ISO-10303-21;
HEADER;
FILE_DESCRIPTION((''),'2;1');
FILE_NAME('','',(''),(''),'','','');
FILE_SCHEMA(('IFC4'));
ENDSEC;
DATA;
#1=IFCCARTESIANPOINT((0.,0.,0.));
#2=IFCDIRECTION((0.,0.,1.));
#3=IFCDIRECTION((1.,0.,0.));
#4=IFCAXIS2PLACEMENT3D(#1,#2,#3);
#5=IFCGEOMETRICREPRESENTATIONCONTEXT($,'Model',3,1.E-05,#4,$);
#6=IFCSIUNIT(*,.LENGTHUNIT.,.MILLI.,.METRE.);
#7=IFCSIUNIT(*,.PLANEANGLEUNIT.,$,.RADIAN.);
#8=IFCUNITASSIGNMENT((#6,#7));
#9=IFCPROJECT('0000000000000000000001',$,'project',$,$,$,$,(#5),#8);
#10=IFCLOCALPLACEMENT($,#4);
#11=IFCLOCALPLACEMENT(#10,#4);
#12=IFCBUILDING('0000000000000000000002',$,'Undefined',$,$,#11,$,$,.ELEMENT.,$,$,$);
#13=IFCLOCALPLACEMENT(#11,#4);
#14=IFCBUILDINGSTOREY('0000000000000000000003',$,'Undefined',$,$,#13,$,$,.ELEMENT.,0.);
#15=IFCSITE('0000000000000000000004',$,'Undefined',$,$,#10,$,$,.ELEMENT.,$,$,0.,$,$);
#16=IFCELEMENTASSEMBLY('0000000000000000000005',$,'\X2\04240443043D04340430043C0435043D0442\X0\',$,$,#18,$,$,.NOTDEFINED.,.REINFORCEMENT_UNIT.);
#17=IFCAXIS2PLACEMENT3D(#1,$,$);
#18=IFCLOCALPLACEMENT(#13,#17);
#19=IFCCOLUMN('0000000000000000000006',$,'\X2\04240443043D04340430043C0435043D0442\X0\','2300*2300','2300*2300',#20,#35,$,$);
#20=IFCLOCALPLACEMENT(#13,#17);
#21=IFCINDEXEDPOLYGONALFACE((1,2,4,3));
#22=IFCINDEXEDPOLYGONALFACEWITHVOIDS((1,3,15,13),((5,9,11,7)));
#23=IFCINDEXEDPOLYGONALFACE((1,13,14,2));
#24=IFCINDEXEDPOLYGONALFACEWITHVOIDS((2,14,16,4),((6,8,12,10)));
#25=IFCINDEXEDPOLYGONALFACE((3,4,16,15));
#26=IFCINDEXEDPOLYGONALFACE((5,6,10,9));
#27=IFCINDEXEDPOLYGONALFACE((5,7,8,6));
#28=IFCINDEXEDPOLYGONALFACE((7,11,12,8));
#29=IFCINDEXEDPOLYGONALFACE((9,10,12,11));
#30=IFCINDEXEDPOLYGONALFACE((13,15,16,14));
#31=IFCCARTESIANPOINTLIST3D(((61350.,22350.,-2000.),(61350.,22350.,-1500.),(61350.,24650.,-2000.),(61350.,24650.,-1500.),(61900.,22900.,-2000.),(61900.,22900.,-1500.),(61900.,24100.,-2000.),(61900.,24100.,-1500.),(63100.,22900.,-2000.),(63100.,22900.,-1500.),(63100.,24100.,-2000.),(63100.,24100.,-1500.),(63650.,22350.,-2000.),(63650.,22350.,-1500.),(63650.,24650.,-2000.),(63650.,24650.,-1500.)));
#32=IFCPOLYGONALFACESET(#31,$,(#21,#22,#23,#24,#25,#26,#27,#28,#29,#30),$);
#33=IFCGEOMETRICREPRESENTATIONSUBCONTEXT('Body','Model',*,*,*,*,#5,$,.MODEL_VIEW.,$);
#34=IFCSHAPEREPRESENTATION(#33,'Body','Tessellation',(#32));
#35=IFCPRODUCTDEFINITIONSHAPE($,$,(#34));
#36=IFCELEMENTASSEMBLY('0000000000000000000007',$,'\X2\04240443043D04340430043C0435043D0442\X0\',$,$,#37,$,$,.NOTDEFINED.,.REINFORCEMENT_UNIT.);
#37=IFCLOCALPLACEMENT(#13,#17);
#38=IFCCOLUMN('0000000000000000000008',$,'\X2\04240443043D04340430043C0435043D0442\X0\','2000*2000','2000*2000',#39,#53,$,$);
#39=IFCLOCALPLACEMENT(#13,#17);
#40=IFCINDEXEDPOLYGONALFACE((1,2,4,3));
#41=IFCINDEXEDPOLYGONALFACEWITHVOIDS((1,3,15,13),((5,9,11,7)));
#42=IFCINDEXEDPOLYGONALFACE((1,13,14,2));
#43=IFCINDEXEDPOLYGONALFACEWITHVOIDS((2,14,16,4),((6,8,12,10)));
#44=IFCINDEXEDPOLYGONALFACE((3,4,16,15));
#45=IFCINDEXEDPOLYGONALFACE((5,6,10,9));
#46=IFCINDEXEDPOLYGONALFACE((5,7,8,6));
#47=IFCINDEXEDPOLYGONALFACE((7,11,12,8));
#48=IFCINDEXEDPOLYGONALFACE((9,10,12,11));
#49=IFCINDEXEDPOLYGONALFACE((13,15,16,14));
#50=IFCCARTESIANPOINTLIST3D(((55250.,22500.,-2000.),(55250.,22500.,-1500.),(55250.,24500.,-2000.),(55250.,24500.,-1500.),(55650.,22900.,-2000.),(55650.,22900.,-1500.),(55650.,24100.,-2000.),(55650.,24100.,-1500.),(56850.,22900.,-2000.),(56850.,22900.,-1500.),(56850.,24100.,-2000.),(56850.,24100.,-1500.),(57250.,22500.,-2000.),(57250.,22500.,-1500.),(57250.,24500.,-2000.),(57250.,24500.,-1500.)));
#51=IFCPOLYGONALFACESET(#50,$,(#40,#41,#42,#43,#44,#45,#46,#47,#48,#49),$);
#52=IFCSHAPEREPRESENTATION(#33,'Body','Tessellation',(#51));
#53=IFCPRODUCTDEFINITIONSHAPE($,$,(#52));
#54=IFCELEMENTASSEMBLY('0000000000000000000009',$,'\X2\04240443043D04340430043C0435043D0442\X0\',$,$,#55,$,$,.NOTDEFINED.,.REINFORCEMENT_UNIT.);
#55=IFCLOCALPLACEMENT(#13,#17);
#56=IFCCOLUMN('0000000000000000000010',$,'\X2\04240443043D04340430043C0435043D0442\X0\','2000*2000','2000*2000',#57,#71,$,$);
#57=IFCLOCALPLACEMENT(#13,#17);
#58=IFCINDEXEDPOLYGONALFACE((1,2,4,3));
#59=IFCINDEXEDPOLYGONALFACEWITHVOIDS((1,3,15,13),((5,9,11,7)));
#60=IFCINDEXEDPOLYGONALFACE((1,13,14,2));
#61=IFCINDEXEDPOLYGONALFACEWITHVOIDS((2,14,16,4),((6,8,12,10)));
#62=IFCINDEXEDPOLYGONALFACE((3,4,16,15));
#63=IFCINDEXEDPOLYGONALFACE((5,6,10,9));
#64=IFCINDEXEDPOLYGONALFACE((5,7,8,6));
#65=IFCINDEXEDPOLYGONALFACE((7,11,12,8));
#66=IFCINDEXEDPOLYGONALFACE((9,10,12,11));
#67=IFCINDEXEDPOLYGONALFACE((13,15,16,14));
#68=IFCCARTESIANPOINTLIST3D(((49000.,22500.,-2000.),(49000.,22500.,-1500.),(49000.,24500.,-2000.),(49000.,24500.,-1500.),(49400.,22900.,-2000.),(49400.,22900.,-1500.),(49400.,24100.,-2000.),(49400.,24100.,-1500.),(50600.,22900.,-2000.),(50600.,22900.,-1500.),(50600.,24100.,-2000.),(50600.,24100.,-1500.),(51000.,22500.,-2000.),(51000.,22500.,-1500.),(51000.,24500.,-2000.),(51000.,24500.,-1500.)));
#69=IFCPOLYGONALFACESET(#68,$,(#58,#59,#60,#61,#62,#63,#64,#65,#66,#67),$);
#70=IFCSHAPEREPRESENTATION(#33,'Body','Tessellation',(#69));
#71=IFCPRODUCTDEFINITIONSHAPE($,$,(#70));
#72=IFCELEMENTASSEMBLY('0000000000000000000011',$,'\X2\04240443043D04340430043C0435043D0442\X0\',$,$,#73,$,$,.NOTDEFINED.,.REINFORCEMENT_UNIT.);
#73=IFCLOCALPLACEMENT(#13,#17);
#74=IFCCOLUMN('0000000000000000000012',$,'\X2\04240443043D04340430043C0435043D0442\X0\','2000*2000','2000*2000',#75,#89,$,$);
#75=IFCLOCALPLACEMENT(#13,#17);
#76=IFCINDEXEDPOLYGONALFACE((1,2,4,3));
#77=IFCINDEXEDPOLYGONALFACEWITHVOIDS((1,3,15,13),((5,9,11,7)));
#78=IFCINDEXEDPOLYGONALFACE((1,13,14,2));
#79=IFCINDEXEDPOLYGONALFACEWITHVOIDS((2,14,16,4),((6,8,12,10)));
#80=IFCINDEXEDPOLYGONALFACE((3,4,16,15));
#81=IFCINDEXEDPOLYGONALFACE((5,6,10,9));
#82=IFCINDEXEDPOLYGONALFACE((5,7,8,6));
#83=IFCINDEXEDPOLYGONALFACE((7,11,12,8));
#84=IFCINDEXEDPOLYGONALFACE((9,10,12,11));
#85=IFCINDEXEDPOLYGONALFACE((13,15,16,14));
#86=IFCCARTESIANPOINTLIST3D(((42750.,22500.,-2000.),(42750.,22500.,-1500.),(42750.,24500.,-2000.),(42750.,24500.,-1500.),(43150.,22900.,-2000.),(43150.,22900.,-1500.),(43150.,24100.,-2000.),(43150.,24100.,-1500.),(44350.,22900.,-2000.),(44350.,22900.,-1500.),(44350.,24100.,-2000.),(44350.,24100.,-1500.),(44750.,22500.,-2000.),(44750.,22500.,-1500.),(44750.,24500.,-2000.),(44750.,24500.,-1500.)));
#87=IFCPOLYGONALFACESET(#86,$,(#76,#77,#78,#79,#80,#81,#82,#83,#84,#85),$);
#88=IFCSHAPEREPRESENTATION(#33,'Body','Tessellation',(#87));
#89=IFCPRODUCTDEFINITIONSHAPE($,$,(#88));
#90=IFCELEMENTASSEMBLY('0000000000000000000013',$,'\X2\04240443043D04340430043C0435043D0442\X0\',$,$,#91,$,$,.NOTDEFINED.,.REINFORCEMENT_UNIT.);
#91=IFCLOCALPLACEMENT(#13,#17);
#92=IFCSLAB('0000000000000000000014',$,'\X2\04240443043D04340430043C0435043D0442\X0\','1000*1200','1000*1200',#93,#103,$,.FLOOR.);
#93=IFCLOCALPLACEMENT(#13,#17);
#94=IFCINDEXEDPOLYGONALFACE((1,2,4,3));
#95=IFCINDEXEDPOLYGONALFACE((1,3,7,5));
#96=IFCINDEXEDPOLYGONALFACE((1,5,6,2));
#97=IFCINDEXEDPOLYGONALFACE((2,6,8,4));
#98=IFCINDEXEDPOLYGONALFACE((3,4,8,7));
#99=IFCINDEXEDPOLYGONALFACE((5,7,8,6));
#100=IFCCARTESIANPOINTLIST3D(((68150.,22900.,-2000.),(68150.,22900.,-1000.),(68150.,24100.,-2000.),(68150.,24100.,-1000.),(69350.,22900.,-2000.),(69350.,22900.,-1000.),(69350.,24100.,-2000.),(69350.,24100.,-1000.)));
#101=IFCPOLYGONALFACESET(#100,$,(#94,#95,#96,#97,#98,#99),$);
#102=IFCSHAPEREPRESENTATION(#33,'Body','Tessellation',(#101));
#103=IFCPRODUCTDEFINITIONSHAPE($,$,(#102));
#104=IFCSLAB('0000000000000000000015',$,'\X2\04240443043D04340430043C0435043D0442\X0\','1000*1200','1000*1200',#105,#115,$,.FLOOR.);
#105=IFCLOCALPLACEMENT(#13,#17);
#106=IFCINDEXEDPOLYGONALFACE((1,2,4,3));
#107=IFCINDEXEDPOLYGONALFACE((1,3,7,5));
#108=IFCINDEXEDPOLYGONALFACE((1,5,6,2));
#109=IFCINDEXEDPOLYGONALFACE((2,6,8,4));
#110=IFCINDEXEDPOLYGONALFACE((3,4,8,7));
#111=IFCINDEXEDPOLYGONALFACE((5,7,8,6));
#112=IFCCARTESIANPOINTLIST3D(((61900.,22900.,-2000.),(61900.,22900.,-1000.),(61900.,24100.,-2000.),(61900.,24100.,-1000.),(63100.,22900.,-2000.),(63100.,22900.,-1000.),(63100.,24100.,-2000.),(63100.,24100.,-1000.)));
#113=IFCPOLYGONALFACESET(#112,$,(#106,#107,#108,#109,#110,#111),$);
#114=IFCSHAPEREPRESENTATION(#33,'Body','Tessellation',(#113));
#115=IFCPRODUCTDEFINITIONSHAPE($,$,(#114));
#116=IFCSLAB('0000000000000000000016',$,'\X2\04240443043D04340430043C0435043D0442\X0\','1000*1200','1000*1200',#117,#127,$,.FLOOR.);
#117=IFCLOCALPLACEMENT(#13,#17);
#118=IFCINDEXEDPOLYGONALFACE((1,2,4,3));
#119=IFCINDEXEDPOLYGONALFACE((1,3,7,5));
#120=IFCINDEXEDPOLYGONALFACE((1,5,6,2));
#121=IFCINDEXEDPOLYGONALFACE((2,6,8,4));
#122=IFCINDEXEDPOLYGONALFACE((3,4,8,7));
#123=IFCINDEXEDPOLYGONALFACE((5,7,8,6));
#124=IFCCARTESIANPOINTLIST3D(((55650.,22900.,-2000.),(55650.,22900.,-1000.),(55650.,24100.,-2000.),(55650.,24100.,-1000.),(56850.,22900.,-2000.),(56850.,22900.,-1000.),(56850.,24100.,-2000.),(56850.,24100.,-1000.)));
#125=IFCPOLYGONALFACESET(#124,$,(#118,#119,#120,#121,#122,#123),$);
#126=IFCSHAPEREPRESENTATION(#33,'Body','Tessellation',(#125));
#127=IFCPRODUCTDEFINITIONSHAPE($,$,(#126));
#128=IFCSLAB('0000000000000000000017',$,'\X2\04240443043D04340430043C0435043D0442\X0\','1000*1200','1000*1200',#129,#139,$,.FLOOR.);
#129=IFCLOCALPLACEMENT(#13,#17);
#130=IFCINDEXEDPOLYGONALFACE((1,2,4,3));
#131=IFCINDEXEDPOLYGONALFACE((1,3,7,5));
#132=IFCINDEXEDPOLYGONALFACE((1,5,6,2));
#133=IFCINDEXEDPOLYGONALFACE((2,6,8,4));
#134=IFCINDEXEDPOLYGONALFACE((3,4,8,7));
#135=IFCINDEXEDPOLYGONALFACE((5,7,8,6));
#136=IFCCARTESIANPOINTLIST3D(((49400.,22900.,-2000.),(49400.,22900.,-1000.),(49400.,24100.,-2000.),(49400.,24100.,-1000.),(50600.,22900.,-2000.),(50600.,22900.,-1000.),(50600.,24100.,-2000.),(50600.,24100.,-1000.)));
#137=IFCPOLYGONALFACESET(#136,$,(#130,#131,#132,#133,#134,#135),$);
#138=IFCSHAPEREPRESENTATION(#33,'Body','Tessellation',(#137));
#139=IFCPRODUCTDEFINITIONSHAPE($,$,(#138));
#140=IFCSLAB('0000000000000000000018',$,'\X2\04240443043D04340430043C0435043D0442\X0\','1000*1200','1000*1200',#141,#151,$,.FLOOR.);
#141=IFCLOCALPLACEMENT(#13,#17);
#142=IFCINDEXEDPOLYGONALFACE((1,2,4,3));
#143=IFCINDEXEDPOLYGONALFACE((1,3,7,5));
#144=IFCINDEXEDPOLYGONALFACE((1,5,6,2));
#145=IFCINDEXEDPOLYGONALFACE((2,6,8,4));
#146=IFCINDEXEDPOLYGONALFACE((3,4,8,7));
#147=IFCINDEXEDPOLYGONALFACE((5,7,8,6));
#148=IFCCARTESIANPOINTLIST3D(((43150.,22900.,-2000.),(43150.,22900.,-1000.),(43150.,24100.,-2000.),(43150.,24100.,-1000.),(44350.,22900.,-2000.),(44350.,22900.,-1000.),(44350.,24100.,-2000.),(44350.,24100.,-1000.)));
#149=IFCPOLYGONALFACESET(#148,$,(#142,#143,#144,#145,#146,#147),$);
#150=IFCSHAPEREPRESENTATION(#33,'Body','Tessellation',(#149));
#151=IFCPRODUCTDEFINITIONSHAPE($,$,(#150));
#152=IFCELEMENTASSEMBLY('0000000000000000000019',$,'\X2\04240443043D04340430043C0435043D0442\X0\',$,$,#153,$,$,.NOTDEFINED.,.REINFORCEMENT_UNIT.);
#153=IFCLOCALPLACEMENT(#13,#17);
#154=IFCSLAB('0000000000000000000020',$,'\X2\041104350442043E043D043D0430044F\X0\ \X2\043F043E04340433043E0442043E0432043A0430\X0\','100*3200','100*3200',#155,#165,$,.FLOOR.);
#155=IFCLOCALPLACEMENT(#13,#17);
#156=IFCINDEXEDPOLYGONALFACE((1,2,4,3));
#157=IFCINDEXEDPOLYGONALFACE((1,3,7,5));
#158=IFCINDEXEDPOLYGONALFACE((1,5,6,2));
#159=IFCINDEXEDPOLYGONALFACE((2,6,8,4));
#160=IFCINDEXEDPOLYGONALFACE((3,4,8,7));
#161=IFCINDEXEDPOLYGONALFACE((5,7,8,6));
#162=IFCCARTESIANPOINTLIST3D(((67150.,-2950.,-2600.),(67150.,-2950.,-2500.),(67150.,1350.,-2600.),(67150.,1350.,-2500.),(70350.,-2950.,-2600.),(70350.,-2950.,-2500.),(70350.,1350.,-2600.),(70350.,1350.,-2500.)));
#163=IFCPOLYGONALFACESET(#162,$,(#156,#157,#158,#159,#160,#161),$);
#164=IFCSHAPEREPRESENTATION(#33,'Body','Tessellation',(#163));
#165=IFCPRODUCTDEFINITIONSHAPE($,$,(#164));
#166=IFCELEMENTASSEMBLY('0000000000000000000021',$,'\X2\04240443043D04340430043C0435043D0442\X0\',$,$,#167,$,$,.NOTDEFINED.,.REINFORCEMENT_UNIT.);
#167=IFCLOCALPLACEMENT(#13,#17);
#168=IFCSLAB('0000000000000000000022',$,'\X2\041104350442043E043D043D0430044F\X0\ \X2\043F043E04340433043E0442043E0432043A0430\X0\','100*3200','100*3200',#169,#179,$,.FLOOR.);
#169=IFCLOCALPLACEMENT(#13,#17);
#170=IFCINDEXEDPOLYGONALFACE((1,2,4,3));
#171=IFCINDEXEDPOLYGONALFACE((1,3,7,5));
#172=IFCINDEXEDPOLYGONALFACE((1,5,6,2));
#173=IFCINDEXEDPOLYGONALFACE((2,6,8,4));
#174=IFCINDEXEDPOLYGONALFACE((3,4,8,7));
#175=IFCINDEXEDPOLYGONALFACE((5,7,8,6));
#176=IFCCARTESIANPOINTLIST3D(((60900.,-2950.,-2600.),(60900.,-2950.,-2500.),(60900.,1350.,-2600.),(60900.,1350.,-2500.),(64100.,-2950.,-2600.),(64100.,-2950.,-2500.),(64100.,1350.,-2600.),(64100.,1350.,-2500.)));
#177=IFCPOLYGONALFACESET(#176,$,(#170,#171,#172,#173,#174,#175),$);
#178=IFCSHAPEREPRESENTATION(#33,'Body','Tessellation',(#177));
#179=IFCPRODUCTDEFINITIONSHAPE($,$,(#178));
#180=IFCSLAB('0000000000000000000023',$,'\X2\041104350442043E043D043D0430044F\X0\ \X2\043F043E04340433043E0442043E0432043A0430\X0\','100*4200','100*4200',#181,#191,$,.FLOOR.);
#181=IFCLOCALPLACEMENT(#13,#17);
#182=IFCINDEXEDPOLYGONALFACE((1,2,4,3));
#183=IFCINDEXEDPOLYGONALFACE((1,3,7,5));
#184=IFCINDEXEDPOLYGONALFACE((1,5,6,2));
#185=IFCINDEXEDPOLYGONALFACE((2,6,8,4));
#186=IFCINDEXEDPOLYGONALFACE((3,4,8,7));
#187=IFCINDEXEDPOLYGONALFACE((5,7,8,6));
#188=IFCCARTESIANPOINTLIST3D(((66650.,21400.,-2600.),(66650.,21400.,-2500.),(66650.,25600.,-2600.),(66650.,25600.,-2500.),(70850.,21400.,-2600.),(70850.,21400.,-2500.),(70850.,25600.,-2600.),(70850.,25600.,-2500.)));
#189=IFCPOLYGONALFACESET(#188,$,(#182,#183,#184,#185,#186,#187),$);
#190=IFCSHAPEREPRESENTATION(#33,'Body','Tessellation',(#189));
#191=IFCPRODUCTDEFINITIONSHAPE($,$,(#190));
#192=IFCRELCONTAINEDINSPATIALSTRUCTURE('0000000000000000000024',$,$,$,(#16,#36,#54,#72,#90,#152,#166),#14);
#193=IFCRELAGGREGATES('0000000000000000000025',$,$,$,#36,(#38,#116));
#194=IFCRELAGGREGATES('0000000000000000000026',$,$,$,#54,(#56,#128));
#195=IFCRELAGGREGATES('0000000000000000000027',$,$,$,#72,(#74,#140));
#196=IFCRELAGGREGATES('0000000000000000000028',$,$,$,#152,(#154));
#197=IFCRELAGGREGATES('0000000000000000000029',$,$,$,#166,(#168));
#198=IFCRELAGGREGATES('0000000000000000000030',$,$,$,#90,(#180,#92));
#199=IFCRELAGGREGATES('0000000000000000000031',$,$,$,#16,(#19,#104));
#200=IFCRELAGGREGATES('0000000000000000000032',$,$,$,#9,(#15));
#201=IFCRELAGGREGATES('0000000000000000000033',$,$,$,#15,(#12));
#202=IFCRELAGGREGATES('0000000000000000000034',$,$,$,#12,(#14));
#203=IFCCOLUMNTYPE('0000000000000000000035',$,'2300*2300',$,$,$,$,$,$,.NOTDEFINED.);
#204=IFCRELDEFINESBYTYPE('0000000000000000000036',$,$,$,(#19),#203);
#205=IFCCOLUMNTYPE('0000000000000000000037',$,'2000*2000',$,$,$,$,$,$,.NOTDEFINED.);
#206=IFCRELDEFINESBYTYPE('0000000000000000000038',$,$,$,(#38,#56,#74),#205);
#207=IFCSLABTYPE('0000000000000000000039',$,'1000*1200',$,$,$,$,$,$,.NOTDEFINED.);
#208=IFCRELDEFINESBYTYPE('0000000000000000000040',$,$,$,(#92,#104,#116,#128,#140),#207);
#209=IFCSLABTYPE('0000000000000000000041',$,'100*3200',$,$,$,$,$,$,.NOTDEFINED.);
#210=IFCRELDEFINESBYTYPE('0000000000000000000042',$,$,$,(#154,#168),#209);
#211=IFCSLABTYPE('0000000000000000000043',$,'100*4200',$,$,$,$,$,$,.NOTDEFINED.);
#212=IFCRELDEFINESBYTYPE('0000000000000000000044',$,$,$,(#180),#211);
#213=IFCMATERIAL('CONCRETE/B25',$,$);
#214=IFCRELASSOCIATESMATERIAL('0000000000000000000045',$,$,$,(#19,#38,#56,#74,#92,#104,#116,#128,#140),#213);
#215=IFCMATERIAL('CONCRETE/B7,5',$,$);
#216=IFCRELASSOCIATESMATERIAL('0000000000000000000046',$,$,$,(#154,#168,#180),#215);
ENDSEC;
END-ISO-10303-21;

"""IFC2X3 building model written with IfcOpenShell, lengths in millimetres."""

from ifc_helpers import new_model, si_unit, frame, origin_with_axes, origin_2d_with_axis, place, context, subcontext, project, spatial, polyline, rectangle, outline, extrude, boolean, material, type_object, element, aggregate, save


model = new_model("IFC2X3")

# Units and contexts
model_context = context("Model", 3, precision=1e-05, world=origin_with_axes())
body_context = subcontext(model_context, "Body", "Model", "MODEL_VIEW")
ifc_project = project(units=[si_unit("LENGTHUNIT", "METRE", prefix="MILLI"), si_unit("PLANEANGLEUNIT", "RADIAN")], contexts=[model_context])

# Site, building, storey
site_placement = place(None, origin_with_axes())
site = spatial("IfcSite", under=ifc_project, at=site_placement, Name="Undefined", CompositionType="ELEMENT", RefElevation=0.0)
building_placement = place(site_placement, origin_with_axes())
building = spatial("IfcBuilding", under=site, at=building_placement, Name="Undefined", CompositionType="ELEMENT")
storey_placement = place(building_placement, origin_with_axes())
storey = spatial("IfcBuildingStorey", under=building, at=storey_placement, Name="Undefined", CompositionType="ELEMENT", Elevation=0.0)

# Element assemblies, columns
assembly_1_placement = place(storey_placement, origin_with_axes())
assembly_1 = element("IfcElementAssembly", 1, at=assembly_1_placement, inside=storey, Name="Фундамент", AssemblyPlace="NOTDEFINED", PredefinedType="REINFORCEMENT_UNIT")
ifc_material_1 = material(Name="CONCRETE/B25")
column_type_1 = type_object("IfcColumnType", Name="2300*2300", PredefinedType="NOTDEFINED")
column_1_placement = place(assembly_1_placement, frame((62500.0, 23500.0, -2000.0), z_axis=(0.0, 0.0, 1.0), x_axis=(0.0, -1.0, 0.0)))
column_1 = element("IfcColumn", 2, at=column_1_placement, type_object=column_type_1, material=ifc_material_1, Name="Фундамент", Description="2300*2300", ObjectType="2300*2300", context=body_context, shape_type="CSG", body=[
    boolean("DIFFERENCE", extrude(rectangle(XDim=2300.0, YDim=2300.0, at=origin_2d_with_axis()), frame((0.0, 0.0, 500.0), z_axis=(0.0, 0.0, -1.0), x_axis=(0.0, 1.0, 0.0)), (0.0, 0.0, 1.0), 500.0), extrude(outline(polyline([(0.0, 0.0), (1200.0, 0.0), (1200.0, 1200.0), (0.0, 1200.0), (0.0, 0.0)])), frame((-600.0, -600.0, -100.0), z_axis=(0.0, 0.0, 1.0), x_axis=(1.0, 0.0, 0.0)), (0.0, 0.0, 1.0), 700.0)),
])
assembly_2_placement = place(storey_placement, origin_with_axes())
assembly_2 = element("IfcElementAssembly", 3, at=assembly_2_placement, inside=storey, Name="Фундамент", AssemblyPlace="NOTDEFINED", PredefinedType="REINFORCEMENT_UNIT")
column_type_2 = type_object("IfcColumnType", Name="2000*2000", PredefinedType="NOTDEFINED")
column_2_placement = place(assembly_2_placement, frame((56250.0, 23500.0, -2000.0), z_axis=(0.0, 0.0, 1.0), x_axis=(0.0, -1.0, 0.0)))
column_2 = element("IfcColumn", 4, at=column_2_placement, type_object=column_type_2, material=ifc_material_1, Name="Фундамент", Description="2000*2000", ObjectType="2000*2000", context=body_context, shape_type="CSG", body=[
    boolean("DIFFERENCE", extrude(rectangle(XDim=2000.0, YDim=2000.0, at=origin_2d_with_axis()), frame((0.0, 0.0, 500.0), z_axis=(0.0, 0.0, -1.0), x_axis=(0.0, 1.0, 0.0)), (0.0, 0.0, 1.0), 500.0), extrude(outline(polyline([(0.0, 0.0), (1200.0, 0.0), (1200.0, 1200.0), (0.0, 1200.0), (0.0, 0.0)])), frame((-600.0, -600.0, -100.0), z_axis=(0.0, 0.0, 1.0), x_axis=(1.0, 0.0, 0.0)), (0.0, 0.0, 1.0), 700.0)),
])
assembly_3_placement = place(storey_placement, origin_with_axes())
assembly_3 = element("IfcElementAssembly", 5, at=assembly_3_placement, inside=storey, Name="Фундамент", AssemblyPlace="NOTDEFINED", PredefinedType="REINFORCEMENT_UNIT")
column_3_placement = place(assembly_3_placement, frame((50000.0, 23500.0, -2000.0), z_axis=(0.0, 0.0, 1.0), x_axis=(0.0, -1.0, 0.0)))
column_3 = element("IfcColumn", 6, at=column_3_placement, type_object=column_type_2, material=ifc_material_1, Name="Фундамент", Description="2000*2000", ObjectType="2000*2000", context=body_context, shape_type="CSG", body=[
    boolean("DIFFERENCE", extrude(rectangle(XDim=2000.0, YDim=2000.0, at=origin_2d_with_axis()), frame((0.0, 0.0, 500.0), z_axis=(0.0, 0.0, -1.0), x_axis=(0.0, 1.0, 0.0)), (0.0, 0.0, 1.0), 500.0), extrude(outline(polyline([(0.0, 0.0), (1200.0, 0.0), (1200.0, 1200.0), (0.0, 1200.0), (0.0, 0.0)])), frame((-600.0, -600.0, -100.0), z_axis=(0.0, 0.0, 1.0), x_axis=(1.0, 0.0, 0.0)), (0.0, 0.0, 1.0), 700.0)),
])
assembly_4_placement = place(storey_placement, origin_with_axes())
assembly_4 = element("IfcElementAssembly", 7, at=assembly_4_placement, inside=storey, Name="Фундамент", AssemblyPlace="NOTDEFINED", PredefinedType="REINFORCEMENT_UNIT")
column_4_placement = place(assembly_4_placement, frame((43750.0, 23500.0, -2000.0), z_axis=(0.0, 0.0, 1.0), x_axis=(0.0, -1.0, 0.0)))
column_4 = element("IfcColumn", 8, at=column_4_placement, type_object=column_type_2, material=ifc_material_1, Name="Фундамент", Description="2000*2000", ObjectType="2000*2000", context=body_context, shape_type="CSG", body=[
    boolean("DIFFERENCE", extrude(rectangle(XDim=2000.0, YDim=2000.0, at=origin_2d_with_axis()), frame((0.0, 0.0, 500.0), z_axis=(0.0, 0.0, -1.0), x_axis=(0.0, 1.0, 0.0)), (0.0, 0.0, 1.0), 500.0), extrude(outline(polyline([(0.0, 0.0), (1200.0, 0.0), (1200.0, 1200.0), (0.0, 1200.0), (0.0, 0.0)])), frame((-600.0, -600.0, -100.0), z_axis=(0.0, 0.0, 1.0), x_axis=(1.0, 0.0, 0.0)), (0.0, 0.0, 1.0), 700.0)),
])

# Element assembly, slab
assembly_5_placement = place(storey_placement, origin_with_axes())
assembly_5 = element("IfcElementAssembly", 9, at=assembly_5_placement, inside=storey, Name="Фундамент", AssemblyPlace="NOTDEFINED", PredefinedType="REINFORCEMENT_UNIT")
slab_type_1 = type_object("IfcSlabType", Name="1000*1200", PredefinedType="NOTDEFINED")
slab_1_placement = place(assembly_5_placement, frame((68150.0, 24100.0, -1500.0), z_axis=(0.0, 0.0, 1.0), x_axis=(0.0, -1.0, 0.0)))
slab_1 = element("IfcSlab", 10, at=slab_1_placement, type_object=slab_type_1, material=ifc_material_1, Name="Фундамент", Description="1000*1200", ObjectType="1000*1200", PredefinedType="FLOOR", context=body_context, shape_type="SweptSolid", body=[
    extrude(outline(polyline([(0.0, 0.0), (1200.0, 0.0), (1200.0, 1200.0), (0.0, 1200.0), (0.0, 0.0)])), frame((0.0, 0.0, -500.0), z_axis=(0.0, 0.0, 1.0), x_axis=(1.0, 0.0, 0.0)), (0.0, 0.0, 1.0), 1000.0),
])

# Slabs
slab_2_placement = place(assembly_1_placement, frame((61900.0, 24100.0, -1500.0), z_axis=(0.0, 0.0, 1.0), x_axis=(0.0, -1.0, 0.0)))
slab_2 = element("IfcSlab", 11, at=slab_2_placement, type_object=slab_type_1, material=ifc_material_1, Name="Фундамент", Description="1000*1200", ObjectType="1000*1200", PredefinedType="FLOOR", context=body_context, shape_type="SweptSolid", body=[
    extrude(outline(polyline([(0.0, 0.0), (1200.0, 0.0), (1200.0, 1200.0), (0.0, 1200.0), (0.0, 0.0)])), frame((0.0, 0.0, -500.0), z_axis=(0.0, 0.0, 1.0), x_axis=(1.0, 0.0, 0.0)), (0.0, 0.0, 1.0), 1000.0),
])
slab_3_placement = place(assembly_2_placement, frame((55650.0, 24100.0, -1500.0), z_axis=(0.0, 0.0, 1.0), x_axis=(0.0, -1.0, 0.0)))
slab_3 = element("IfcSlab", 12, at=slab_3_placement, type_object=slab_type_1, material=ifc_material_1, Name="Фундамент", Description="1000*1200", ObjectType="1000*1200", PredefinedType="FLOOR", context=body_context, shape_type="SweptSolid", body=[
    extrude(outline(polyline([(0.0, 0.0), (1200.0, 0.0), (1200.0, 1200.0), (0.0, 1200.0), (0.0, 0.0)])), frame((0.0, 0.0, -500.0), z_axis=(0.0, 0.0, 1.0), x_axis=(1.0, 0.0, 0.0)), (0.0, 0.0, 1.0), 1000.0),
])
aggregate(assembly_2, [column_2, slab_3])
slab_4_placement = place(assembly_3_placement, frame((49400.0, 24100.0, -1500.0), z_axis=(0.0, 0.0, 1.0), x_axis=(0.0, -1.0, 0.0)))
slab_4 = element("IfcSlab", 13, at=slab_4_placement, type_object=slab_type_1, material=ifc_material_1, Name="Фундамент", Description="1000*1200", ObjectType="1000*1200", PredefinedType="FLOOR", context=body_context, shape_type="SweptSolid", body=[
    extrude(outline(polyline([(0.0, 0.0), (1200.0, 0.0), (1200.0, 1200.0), (0.0, 1200.0), (0.0, 0.0)])), frame((0.0, 0.0, -500.0), z_axis=(0.0, 0.0, 1.0), x_axis=(1.0, 0.0, 0.0)), (0.0, 0.0, 1.0), 1000.0),
])
aggregate(assembly_3, [column_3, slab_4])
slab_5_placement = place(assembly_4_placement, frame((43150.0, 24100.0, -1500.0), z_axis=(0.0, 0.0, 1.0), x_axis=(0.0, -1.0, 0.0)))
slab_5 = element("IfcSlab", 14, at=slab_5_placement, type_object=slab_type_1, material=ifc_material_1, Name="Фундамент", Description="1000*1200", ObjectType="1000*1200", PredefinedType="FLOOR", context=body_context, shape_type="SweptSolid", body=[
    extrude(outline(polyline([(0.0, 0.0), (1200.0, 0.0), (1200.0, 1200.0), (0.0, 1200.0), (0.0, 0.0)])), frame((0.0, 0.0, -500.0), z_axis=(0.0, 0.0, 1.0), x_axis=(1.0, 0.0, 0.0)), (0.0, 0.0, 1.0), 1000.0),
])
aggregate(assembly_4, [column_4, slab_5])

# Element assemblies, slabs
assembly_6_placement = place(storey_placement, origin_with_axes())
assembly_6 = element("IfcElementAssembly", 15, at=assembly_6_placement, inside=storey, Name="Фундамент", AssemblyPlace="NOTDEFINED", PredefinedType="REINFORCEMENT_UNIT")
ifc_material_2 = material(Name="CONCRETE/B7,5")
slab_type_2 = type_object("IfcSlabType", Name="100*3200", PredefinedType="NOTDEFINED")
slab_6_placement = place(assembly_6_placement, frame((67150.0, 1350.0, -2550.0), z_axis=(0.0, 0.0, 1.0), x_axis=(0.0, -1.0, 0.0)))
slab_6 = element("IfcSlab", 16, at=slab_6_placement, type_object=slab_type_2, material=ifc_material_2, Name="Бетонная подготовка", Description="100*3200", ObjectType="100*3200", PredefinedType="FLOOR", context=body_context, shape_type="SweptSolid", body=[
    extrude(outline(polyline([(0.0, 0.0), (4300.0, 0.0), (4300.0, 3200.0), (0.0, 3200.0), (0.0, 0.0)])), frame((0.0, 0.0, -50.0), z_axis=(0.0, 0.0, 1.0), x_axis=(1.0, 0.0, 0.0)), (0.0, 0.0, 1.0), 100.0),
])
aggregate(assembly_6, [slab_6])
assembly_7_placement = place(storey_placement, origin_with_axes())
assembly_7 = element("IfcElementAssembly", 17, at=assembly_7_placement, inside=storey, Name="Фундамент", AssemblyPlace="NOTDEFINED", PredefinedType="REINFORCEMENT_UNIT")
slab_7_placement = place(assembly_7_placement, frame((60900.0, 1350.0, -2550.0), z_axis=(0.0, 0.0, 1.0), x_axis=(0.0, -1.0, 0.0)))
slab_7 = element("IfcSlab", 18, at=slab_7_placement, type_object=slab_type_2, material=ifc_material_2, Name="Бетонная подготовка", Description="100*3200", ObjectType="100*3200", PredefinedType="FLOOR", context=body_context, shape_type="SweptSolid", body=[
    extrude(outline(polyline([(0.0, 0.0), (4300.0, 0.0), (4300.0, 3200.0), (0.0, 3200.0), (0.0, 0.0)])), frame((0.0, 0.0, -50.0), z_axis=(0.0, 0.0, 1.0), x_axis=(1.0, 0.0, 0.0)), (0.0, 0.0, 1.0), 100.0),
])
aggregate(assembly_7, [slab_7])

# Slab
slab_type_3 = type_object("IfcSlabType", Name="100*4200", PredefinedType="NOTDEFINED")
slab_8_placement = place(assembly_5_placement, frame((66650.0, 25600.0, -2550.0), z_axis=(0.0, 0.0, 1.0), x_axis=(0.0, -1.0, 0.0)))
slab_8 = element("IfcSlab", 19, at=slab_8_placement, type_object=slab_type_3, material=ifc_material_2, Name="Бетонная подготовка", Description="100*4200", ObjectType="100*4200", PredefinedType="FLOOR", context=body_context, shape_type="SweptSolid", body=[
    extrude(outline(polyline([(0.0, 0.0), (4200.0, 0.0), (4200.0, 4200.0), (0.0, 4200.0), (0.0, 0.0)])), frame((0.0, 0.0, -50.0), z_axis=(0.0, 0.0, 1.0), x_axis=(1.0, 0.0, 0.0)), (0.0, 0.0, 1.0), 100.0),
])
aggregate(assembly_5, [slab_8, slab_1])
aggregate(assembly_1, [column_1, slab_2])

save(model, "model.ifc")
